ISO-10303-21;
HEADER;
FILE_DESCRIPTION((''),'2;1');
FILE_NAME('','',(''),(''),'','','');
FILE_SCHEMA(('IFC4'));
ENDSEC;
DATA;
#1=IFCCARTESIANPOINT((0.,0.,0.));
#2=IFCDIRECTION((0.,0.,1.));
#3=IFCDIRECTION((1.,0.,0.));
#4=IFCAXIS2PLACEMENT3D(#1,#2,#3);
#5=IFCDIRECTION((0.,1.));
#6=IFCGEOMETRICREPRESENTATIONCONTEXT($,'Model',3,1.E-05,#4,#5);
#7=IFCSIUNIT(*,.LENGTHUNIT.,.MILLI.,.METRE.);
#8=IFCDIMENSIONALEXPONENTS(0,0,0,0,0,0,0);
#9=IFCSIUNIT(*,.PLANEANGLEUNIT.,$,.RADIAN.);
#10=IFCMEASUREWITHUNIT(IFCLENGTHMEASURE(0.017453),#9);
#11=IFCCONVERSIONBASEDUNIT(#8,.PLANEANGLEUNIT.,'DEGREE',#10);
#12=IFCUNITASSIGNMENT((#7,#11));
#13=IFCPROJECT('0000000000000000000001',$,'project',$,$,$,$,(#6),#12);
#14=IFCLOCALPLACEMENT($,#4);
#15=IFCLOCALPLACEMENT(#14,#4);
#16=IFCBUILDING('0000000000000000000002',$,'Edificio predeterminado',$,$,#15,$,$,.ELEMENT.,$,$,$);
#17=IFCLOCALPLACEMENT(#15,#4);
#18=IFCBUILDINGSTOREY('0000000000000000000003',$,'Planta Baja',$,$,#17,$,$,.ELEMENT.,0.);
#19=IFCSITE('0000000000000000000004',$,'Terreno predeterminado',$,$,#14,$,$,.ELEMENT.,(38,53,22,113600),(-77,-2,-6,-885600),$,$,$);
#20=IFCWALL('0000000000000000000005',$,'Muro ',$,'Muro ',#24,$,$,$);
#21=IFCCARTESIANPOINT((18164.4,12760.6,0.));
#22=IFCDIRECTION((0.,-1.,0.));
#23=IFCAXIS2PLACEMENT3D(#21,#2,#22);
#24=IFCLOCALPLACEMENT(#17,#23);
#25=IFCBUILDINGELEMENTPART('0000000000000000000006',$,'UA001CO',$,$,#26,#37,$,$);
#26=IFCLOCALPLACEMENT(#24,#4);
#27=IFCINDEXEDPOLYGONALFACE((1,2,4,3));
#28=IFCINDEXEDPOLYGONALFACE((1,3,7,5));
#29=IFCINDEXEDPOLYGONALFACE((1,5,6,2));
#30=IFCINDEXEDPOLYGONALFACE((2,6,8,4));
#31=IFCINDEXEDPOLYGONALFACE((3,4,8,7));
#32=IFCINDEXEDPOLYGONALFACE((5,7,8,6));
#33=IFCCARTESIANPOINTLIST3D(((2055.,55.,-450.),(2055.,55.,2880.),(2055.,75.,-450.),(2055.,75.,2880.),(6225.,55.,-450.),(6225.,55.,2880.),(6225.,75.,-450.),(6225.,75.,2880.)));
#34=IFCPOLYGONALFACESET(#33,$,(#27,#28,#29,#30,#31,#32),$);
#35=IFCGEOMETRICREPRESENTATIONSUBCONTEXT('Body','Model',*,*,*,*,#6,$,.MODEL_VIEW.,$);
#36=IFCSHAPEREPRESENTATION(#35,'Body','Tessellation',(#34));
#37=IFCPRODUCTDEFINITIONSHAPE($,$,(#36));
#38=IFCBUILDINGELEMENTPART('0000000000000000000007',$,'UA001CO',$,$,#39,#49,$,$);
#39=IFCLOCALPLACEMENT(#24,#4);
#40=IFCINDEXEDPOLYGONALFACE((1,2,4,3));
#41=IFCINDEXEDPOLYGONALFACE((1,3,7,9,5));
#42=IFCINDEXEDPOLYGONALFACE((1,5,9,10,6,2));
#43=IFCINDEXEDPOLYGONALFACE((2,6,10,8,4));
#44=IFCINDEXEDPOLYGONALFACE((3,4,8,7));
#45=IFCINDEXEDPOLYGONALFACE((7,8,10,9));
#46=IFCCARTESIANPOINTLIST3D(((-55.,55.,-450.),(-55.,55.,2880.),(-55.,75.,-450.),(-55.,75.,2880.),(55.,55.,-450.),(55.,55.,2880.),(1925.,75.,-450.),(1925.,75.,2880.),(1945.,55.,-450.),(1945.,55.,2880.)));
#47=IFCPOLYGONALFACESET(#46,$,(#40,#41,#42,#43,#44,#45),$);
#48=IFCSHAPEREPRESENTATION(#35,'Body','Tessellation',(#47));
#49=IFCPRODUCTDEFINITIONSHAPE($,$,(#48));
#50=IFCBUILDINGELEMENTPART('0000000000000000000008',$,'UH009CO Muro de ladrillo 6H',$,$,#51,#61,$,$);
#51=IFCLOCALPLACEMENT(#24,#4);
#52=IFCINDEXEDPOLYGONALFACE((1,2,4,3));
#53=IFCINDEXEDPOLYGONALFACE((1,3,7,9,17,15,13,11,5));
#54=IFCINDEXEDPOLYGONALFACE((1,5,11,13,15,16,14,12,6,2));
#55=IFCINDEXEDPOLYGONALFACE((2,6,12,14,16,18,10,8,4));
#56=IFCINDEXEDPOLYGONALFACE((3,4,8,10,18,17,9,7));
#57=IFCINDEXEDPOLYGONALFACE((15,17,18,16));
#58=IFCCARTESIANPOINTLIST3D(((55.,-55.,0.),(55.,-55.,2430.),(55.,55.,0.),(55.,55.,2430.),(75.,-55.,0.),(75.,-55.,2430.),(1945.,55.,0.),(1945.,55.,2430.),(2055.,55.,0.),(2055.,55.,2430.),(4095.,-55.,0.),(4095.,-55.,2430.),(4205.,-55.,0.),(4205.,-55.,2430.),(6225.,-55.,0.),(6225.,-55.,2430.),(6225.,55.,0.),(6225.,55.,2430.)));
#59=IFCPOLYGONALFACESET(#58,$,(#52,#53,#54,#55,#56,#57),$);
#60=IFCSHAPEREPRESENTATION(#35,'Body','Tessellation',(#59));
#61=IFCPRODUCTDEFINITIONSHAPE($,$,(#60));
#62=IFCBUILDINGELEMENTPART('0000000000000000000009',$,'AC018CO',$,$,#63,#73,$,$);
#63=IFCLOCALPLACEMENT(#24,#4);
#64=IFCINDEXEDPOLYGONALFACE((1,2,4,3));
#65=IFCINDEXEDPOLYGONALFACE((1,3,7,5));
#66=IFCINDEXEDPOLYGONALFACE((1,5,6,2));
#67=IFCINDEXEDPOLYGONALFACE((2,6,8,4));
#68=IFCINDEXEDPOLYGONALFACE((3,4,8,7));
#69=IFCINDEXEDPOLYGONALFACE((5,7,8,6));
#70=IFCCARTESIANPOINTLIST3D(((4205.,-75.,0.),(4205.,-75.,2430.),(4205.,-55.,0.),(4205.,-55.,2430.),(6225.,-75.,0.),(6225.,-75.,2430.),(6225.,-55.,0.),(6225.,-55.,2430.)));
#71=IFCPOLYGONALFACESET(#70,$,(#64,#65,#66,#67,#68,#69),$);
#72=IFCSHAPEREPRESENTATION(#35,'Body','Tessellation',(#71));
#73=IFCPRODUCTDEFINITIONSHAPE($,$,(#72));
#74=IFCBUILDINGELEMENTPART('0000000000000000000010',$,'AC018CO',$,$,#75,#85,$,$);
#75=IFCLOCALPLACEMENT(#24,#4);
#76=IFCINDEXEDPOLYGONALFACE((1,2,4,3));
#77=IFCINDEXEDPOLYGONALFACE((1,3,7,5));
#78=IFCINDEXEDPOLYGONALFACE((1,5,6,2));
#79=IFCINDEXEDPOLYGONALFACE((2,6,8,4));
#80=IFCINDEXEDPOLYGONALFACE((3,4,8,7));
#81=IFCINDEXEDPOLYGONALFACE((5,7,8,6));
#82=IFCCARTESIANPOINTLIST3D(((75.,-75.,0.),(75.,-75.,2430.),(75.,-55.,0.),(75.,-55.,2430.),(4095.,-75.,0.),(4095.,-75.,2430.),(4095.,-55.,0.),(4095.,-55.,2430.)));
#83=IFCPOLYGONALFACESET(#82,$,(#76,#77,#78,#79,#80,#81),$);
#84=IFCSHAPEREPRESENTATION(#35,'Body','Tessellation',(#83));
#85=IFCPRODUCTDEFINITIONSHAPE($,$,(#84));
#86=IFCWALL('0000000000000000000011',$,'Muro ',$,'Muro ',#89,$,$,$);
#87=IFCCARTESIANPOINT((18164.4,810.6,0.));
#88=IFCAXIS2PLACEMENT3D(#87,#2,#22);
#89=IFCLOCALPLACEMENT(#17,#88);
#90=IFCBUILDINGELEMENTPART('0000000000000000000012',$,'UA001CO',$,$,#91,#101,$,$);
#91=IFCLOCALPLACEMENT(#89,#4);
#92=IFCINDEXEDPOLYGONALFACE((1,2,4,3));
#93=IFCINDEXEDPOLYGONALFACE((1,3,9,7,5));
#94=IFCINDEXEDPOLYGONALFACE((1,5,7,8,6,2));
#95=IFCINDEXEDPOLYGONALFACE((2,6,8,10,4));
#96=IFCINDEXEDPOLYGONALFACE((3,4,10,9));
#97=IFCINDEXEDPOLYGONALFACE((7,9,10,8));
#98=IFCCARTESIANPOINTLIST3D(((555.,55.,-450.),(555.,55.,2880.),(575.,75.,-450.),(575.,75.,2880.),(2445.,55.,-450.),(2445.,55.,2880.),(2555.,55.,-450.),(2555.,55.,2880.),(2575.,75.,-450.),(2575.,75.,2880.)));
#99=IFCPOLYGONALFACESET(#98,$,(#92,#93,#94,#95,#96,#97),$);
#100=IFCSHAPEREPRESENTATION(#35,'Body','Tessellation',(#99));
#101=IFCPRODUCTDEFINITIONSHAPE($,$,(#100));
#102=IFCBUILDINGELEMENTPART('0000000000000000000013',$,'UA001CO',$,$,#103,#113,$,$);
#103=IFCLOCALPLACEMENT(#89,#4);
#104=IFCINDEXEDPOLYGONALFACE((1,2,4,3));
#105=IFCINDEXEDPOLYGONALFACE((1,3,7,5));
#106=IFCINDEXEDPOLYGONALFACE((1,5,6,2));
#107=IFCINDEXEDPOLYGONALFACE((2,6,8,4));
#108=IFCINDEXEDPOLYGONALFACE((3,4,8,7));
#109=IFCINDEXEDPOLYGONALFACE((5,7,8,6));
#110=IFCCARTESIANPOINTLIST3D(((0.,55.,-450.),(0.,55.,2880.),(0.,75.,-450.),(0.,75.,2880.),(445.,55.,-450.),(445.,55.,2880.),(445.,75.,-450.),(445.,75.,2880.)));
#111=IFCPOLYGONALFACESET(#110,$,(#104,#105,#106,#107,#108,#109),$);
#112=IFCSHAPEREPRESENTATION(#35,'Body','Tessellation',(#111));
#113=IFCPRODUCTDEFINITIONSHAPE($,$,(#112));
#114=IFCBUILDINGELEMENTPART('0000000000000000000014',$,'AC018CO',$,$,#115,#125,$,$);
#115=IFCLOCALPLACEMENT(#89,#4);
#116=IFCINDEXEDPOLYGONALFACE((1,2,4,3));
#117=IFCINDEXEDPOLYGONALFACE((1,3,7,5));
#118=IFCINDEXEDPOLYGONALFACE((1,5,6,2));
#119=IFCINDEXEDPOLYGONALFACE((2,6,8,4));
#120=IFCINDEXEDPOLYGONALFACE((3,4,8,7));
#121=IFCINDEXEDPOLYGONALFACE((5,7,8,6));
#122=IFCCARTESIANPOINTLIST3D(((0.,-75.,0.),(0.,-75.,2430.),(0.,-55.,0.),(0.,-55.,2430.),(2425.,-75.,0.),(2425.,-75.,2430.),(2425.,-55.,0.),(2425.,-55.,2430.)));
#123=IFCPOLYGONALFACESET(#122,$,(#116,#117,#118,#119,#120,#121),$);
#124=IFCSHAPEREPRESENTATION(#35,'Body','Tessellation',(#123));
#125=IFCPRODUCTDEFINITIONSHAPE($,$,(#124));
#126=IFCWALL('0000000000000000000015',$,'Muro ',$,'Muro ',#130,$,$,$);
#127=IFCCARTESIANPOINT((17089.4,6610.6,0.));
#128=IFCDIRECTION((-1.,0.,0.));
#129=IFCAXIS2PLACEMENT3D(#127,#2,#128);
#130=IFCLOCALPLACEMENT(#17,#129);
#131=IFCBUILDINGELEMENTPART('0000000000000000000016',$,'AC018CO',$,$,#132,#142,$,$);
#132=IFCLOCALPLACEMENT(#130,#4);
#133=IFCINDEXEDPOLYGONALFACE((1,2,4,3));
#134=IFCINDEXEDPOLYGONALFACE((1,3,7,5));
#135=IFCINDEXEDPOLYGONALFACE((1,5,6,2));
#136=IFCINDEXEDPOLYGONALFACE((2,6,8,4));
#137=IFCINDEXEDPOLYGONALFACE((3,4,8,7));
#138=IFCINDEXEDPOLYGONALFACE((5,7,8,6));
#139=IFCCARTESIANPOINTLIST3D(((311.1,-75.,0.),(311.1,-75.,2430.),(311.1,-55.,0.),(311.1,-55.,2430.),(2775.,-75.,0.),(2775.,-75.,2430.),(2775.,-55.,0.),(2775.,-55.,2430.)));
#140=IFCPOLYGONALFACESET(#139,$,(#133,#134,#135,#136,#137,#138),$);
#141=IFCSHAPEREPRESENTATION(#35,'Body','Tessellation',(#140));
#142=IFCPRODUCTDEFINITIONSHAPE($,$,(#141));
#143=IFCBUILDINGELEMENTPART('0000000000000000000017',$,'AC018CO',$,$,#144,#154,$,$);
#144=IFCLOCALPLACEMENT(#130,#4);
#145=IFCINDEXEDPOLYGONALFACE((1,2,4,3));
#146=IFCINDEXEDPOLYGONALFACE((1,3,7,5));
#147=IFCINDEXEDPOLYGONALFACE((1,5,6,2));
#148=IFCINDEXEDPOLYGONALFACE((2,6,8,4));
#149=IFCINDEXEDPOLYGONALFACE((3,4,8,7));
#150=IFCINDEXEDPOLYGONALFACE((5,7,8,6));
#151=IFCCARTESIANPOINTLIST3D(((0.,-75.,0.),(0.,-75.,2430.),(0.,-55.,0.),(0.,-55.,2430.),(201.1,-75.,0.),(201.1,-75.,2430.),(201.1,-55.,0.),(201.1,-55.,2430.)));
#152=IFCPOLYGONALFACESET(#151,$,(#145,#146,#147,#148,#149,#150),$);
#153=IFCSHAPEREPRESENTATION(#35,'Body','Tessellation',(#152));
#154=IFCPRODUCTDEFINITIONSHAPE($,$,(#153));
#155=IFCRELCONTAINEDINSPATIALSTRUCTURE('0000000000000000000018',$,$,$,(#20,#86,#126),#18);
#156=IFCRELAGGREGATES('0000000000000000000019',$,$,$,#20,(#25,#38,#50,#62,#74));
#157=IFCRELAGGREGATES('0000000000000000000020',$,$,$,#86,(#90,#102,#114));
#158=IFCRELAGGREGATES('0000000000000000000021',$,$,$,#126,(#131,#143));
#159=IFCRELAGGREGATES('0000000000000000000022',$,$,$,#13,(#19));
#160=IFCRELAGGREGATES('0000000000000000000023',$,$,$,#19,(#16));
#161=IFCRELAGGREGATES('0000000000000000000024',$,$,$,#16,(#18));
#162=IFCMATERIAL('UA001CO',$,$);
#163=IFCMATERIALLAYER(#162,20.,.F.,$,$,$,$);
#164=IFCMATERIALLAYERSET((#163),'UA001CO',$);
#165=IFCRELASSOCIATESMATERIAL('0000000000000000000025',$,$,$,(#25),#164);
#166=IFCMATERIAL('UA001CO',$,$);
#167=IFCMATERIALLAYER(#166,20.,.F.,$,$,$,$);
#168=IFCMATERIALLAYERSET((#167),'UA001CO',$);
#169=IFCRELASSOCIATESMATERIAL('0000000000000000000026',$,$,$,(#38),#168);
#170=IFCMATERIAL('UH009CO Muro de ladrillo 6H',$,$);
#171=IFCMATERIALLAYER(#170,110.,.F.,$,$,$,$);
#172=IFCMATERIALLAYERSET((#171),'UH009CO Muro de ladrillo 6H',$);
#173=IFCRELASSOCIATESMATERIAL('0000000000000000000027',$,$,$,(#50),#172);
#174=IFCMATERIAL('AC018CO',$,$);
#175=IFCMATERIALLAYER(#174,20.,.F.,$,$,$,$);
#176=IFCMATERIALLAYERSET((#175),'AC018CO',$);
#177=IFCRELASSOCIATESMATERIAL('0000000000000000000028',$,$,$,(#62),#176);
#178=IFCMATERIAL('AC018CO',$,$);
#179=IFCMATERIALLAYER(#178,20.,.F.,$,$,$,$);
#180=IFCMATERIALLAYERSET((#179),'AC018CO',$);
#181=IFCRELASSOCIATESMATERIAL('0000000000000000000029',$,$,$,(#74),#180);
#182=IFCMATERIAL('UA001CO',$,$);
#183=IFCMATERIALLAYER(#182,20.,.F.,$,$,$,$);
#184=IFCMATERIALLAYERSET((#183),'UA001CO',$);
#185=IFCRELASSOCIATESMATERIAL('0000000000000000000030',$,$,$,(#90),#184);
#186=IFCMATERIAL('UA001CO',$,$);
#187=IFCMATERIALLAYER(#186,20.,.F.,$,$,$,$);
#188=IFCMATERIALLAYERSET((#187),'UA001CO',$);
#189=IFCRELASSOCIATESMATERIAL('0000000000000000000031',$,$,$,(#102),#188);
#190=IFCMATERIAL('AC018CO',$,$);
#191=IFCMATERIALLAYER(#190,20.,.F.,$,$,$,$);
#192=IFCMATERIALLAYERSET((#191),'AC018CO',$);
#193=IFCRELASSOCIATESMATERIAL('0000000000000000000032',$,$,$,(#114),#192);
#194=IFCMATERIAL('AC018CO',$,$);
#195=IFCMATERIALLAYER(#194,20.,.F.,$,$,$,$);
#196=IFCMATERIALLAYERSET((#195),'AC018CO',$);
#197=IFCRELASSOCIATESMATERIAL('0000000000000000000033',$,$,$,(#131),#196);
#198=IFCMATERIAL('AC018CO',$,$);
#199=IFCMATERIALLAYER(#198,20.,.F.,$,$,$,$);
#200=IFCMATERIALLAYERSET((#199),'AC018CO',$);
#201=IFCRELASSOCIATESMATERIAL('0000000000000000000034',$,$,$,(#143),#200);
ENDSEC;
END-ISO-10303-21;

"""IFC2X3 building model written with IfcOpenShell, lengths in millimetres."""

from ifc_helpers import new_model, entity, si_unit, converted_unit, direction, frame, origin_with_axes, place, context, subcontext, project, spatial, polyline, outline, extrude, material, layer, layer_set, layer_usage, element, aggregate, save


model = new_model("IFC2X3")

# Units and contexts
model_context = context("Model", 3, precision=1e-05, world=origin_with_axes(), true_north=direction((0.0, 1.0)))
body_context = subcontext(model_context, "Body", "Model", "MODEL_VIEW")
ifc_project = project(units=[si_unit("LENGTHUNIT", "METRE", prefix="MILLI"), converted_unit("PLANEANGLEUNIT", "DEGREE", entity("IfcLengthMeasure", 0.017453), si_unit("PLANEANGLEUNIT", "RADIAN"), dimensions=[0, 0, 0, 0, 0, 0, 0])], contexts=[model_context])

# Site, building, storey
site_placement = place(None, origin_with_axes())
site = spatial("IfcSite", under=ifc_project, at=site_placement, Name="Terreno predeterminado", CompositionType="ELEMENT", RefLatitude=(38, 53, 22, 113600), RefLongitude=(-77, -2, -6, -885600))
building_placement = place(site_placement, origin_with_axes())
building = spatial("IfcBuilding", under=site, at=building_placement, Name="Edificio predeterminado", CompositionType="ELEMENT")
storey_placement = place(building_placement, origin_with_axes())
storey = spatial("IfcBuildingStorey", under=building, at=storey_placement, Name="Planta Baja", CompositionType="ELEMENT", Elevation=0.0)

# Walls, building element parts
wall_1_placement = place(storey_placement, frame((18164.4, 12760.6, 0.0), z_axis=(0.0, 0.0, 1.0), x_axis=(0.0, -1.0, 0.0)))
wall_1 = element("IfcWall", 1, at=wall_1_placement, inside=storey, Name="Muro ", ObjectType="Muro ")
ifc_material_1 = material(Name="UA001CO")
ifc_layer_1 = layer(ifc_material_1, 20.0, ventilated=False)
ifc_layer_set_1 = layer_set([ifc_layer_1], Name="UA001CO")
ifc_layer_usage_1 = layer_usage(ifc_layer_set_1, "AXIS2", "NEGATIVE", -75.0)
building_element_part_1_placement = place(wall_1_placement, origin_with_axes())
building_element_part_1 = element("IfcBuildingElementPart", 2, at=building_element_part_1_placement, material=ifc_layer_usage_1, Name="UA001CO", context=body_context, shape_type="SweptSolid", body=[
    extrude(outline(polyline([(6225.0, 75.0), (6225.0, 55.0), (2055.0, 55.0), (2055.0, 75.0), (6225.0, 75.0)])), frame((0.0, 0.0, -450.0), z_axis=(0.0, 0.0, 1.0), x_axis=(1.0, 0.0, 0.0)), (0.0, 0.0, 1.0), 3330.0),
])
ifc_material_2 = material(Name="UA001CO")
ifc_layer_2 = layer(ifc_material_2, 20.0, ventilated=False)
ifc_layer_set_2 = layer_set([ifc_layer_2], Name="UA001CO")
ifc_layer_usage_2 = layer_usage(ifc_layer_set_2, "AXIS2", "NEGATIVE", -75.0)
building_element_part_2_placement = place(wall_1_placement, origin_with_axes())
building_element_part_2 = element("IfcBuildingElementPart", 3, at=building_element_part_2_placement, material=ifc_layer_usage_2, Name="UA001CO", context=body_context, shape_type="SweptSolid", body=[
    extrude(outline(polyline([(1925.0, 75.0), (1945.0, 55.0), (55.0, 55.0), (-55.0, 55.0), (-55.0, 75.0), (1925.0, 75.0)])), frame((0.0, 0.0, -450.0), z_axis=(0.0, 0.0, 1.0), x_axis=(1.0, 0.0, 0.0)), (0.0, 0.0, 1.0), 3330.0),
])
ifc_material_3 = material(Name="UH009CO Muro de ladrillo 6H")
ifc_layer_3 = layer(ifc_material_3, 110.0, ventilated=False)
ifc_layer_set_3 = layer_set([ifc_layer_3], Name="UH009CO Muro de ladrillo 6H")
ifc_layer_usage_3 = layer_usage(ifc_layer_set_3, "AXIS2", "NEGATIVE", -55.0)
building_element_part_3_placement = place(wall_1_placement, origin_with_axes())
building_element_part_3 = element("IfcBuildingElementPart", 4, at=building_element_part_3_placement, material=ifc_layer_usage_3, Name="UH009CO Muro de ladrillo 6H", context=body_context, shape_type="SweptSolid", body=[
    extrude(outline(polyline([(6225.0, 55.0), (6225.0, -55.0), (4205.0, -55.0), (4095.0, -55.0), (75.0, -55.0), (55.0, -55.0), (55.0, 55.0), (1945.0, 55.0), (2055.0, 55.0), (6225.0, 55.0)])), origin_with_axes(), (0.0, 0.0, 1.0), 2430.0),
])
ifc_material_4 = material(Name="AC018CO")
ifc_layer_4 = layer(ifc_material_4, 20.0, ventilated=False)
ifc_layer_set_4 = layer_set([ifc_layer_4], Name="AC018CO")
ifc_layer_usage_4 = layer_usage(ifc_layer_set_4, "AXIS2", "NEGATIVE", 55.0)
building_element_part_4_placement = place(wall_1_placement, origin_with_axes())
building_element_part_4 = element("IfcBuildingElementPart", 5, at=building_element_part_4_placement, material=ifc_layer_usage_4, Name="AC018CO", context=body_context, shape_type="SweptSolid", body=[
    extrude(outline(polyline([(6225.0, -55.0), (6225.0, -75.0), (4205.0, -75.0), (4205.0, -55.0), (6225.0, -55.0)])), origin_with_axes(), (0.0, 0.0, 1.0), 2430.0),
])
ifc_material_5 = material(Name="AC018CO")
ifc_layer_5 = layer(ifc_material_5, 20.0, ventilated=False)
ifc_layer_set_5 = layer_set([ifc_layer_5], Name="AC018CO")
ifc_layer_usage_5 = layer_usage(ifc_layer_set_5, "AXIS2", "NEGATIVE", 55.0)
building_element_part_5_placement = place(wall_1_placement, origin_with_axes())
building_element_part_5 = element("IfcBuildingElementPart", 6, at=building_element_part_5_placement, material=ifc_layer_usage_5, Name="AC018CO", context=body_context, shape_type="SweptSolid", body=[
    extrude(outline(polyline([(4095.0, -55.0), (4095.0, -75.0), (75.0, -75.0), (75.0, -55.0), (4095.0, -55.0)])), origin_with_axes(), (0.0, 0.0, 1.0), 2430.0),
])
aggregate(wall_1, [building_element_part_1, building_element_part_2, building_element_part_3, building_element_part_4, building_element_part_5])
wall_2_placement = place(storey_placement, frame((18164.4, 810.6, 0.0), z_axis=(0.0, 0.0, 1.0), x_axis=(0.0, -1.0, 0.0)))
wall_2 = element("IfcWall", 7, at=wall_2_placement, inside=storey, Name="Muro ", ObjectType="Muro ")
ifc_material_6 = material(Name="UA001CO")
ifc_layer_6 = layer(ifc_material_6, 20.0, ventilated=False)
ifc_layer_set_6 = layer_set([ifc_layer_6], Name="UA001CO")
ifc_layer_usage_6 = layer_usage(ifc_layer_set_6, "AXIS2", "NEGATIVE", -75.0)
building_element_part_6_placement = place(wall_2_placement, origin_with_axes())
building_element_part_6 = element("IfcBuildingElementPart", 8, at=building_element_part_6_placement, material=ifc_layer_usage_6, Name="UA001CO", context=body_context, shape_type="SweptSolid", body=[
    extrude(outline(polyline([(2575.0, 75.0), (2555.0, 55.0), (2445.0, 55.0), (555.0, 55.0), (575.0, 75.0), (2575.0, 75.0)])), frame((0.0, 0.0, -450.0), z_axis=(0.0, 0.0, 1.0), x_axis=(1.0, 0.0, 0.0)), (0.0, 0.0, 1.0), 3330.0),
])
ifc_material_7 = material(Name="UA001CO")
ifc_layer_7 = layer(ifc_material_7, 20.0, ventilated=False)
ifc_layer_set_7 = layer_set([ifc_layer_7], Name="UA001CO")
ifc_layer_usage_7 = layer_usage(ifc_layer_set_7, "AXIS2", "NEGATIVE", -75.0)
building_element_part_7_placement = place(wall_2_placement, origin_with_axes())
building_element_part_7 = element("IfcBuildingElementPart", 9, at=building_element_part_7_placement, material=ifc_layer_usage_7, Name="UA001CO", context=body_context, shape_type="SweptSolid", body=[
    extrude(outline(polyline([(445.0, 75.0), (445.0, 55.0), (0.0, 55.0), (0.0, 75.0), (445.0, 75.0)])), frame((0.0, 0.0, -450.0), z_axis=(0.0, 0.0, 1.0), x_axis=(1.0, 0.0, 0.0)), (0.0, 0.0, 1.0), 3330.0),
])
ifc_material_8 = material(Name="AC018CO")
ifc_layer_8 = layer(ifc_material_8, 20.0, ventilated=False)
ifc_layer_set_8 = layer_set([ifc_layer_8], Name="AC018CO")
ifc_layer_usage_8 = layer_usage(ifc_layer_set_8, "AXIS2", "NEGATIVE", 55.0)
building_element_part_8_placement = place(wall_2_placement, origin_with_axes())
building_element_part_8 = element("IfcBuildingElementPart", 10, at=building_element_part_8_placement, material=ifc_layer_usage_8, Name="AC018CO", context=body_context, shape_type="SweptSolid", body=[
    extrude(outline(polyline([(2425.0, -55.0), (2425.0, -75.0), (0.0, -75.0), (0.0, -55.0), (2425.0, -55.0)])), origin_with_axes(), (0.0, 0.0, 1.0), 2430.0),
])
aggregate(wall_2, [building_element_part_6, building_element_part_7, building_element_part_8])
wall_3_placement = place(storey_placement, frame((17089.4, 6610.6, 0.0), z_axis=(0.0, 0.0, 1.0), x_axis=(-1.0, 0.0, 0.0)))
wall_3 = element("IfcWall", 11, at=wall_3_placement, inside=storey, Name="Muro ", ObjectType="Muro ")
ifc_material_9 = material(Name="AC018CO")
ifc_layer_9 = layer(ifc_material_9, 20.0, ventilated=False)
ifc_layer_set_9 = layer_set([ifc_layer_9], Name="AC018CO")
ifc_layer_usage_9 = layer_usage(ifc_layer_set_9, "AXIS2", "NEGATIVE", 55.0)
building_element_part_9_placement = place(wall_3_placement, origin_with_axes())
building_element_part_9 = element("IfcBuildingElementPart", 12, at=building_element_part_9_placement, material=ifc_layer_usage_9, Name="AC018CO", context=body_context, shape_type="SweptSolid", body=[
    extrude(outline(polyline([(2775.0, -55.0), (2775.0, -75.0), (311.1, -75.0), (311.1, -55.0), (2775.0, -55.0)])), origin_with_axes(), (0.0, 0.0, 1.0), 2430.0),
])
ifc_material_10 = material(Name="AC018CO")
ifc_layer_10 = layer(ifc_material_10, 20.0, ventilated=False)
ifc_layer_set_10 = layer_set([ifc_layer_10], Name="AC018CO")
ifc_layer_usage_10 = layer_usage(ifc_layer_set_10, "AXIS2", "NEGATIVE", 55.0)
building_element_part_10_placement = place(wall_3_placement, origin_with_axes())
building_element_part_10 = element("IfcBuildingElementPart", 13, at=building_element_part_10_placement, material=ifc_layer_usage_10, Name="AC018CO", context=body_context, shape_type="SweptSolid", body=[
    extrude(outline(polyline([(201.1, -55.0), (201.1, -75.0), (0.0, -75.0), (0.0, -55.0), (201.1, -55.0)])), origin_with_axes(), (0.0, 0.0, 1.0), 2430.0),
])
aggregate(wall_3, [building_element_part_9, building_element_part_10])

save(model, "model.ifc")
